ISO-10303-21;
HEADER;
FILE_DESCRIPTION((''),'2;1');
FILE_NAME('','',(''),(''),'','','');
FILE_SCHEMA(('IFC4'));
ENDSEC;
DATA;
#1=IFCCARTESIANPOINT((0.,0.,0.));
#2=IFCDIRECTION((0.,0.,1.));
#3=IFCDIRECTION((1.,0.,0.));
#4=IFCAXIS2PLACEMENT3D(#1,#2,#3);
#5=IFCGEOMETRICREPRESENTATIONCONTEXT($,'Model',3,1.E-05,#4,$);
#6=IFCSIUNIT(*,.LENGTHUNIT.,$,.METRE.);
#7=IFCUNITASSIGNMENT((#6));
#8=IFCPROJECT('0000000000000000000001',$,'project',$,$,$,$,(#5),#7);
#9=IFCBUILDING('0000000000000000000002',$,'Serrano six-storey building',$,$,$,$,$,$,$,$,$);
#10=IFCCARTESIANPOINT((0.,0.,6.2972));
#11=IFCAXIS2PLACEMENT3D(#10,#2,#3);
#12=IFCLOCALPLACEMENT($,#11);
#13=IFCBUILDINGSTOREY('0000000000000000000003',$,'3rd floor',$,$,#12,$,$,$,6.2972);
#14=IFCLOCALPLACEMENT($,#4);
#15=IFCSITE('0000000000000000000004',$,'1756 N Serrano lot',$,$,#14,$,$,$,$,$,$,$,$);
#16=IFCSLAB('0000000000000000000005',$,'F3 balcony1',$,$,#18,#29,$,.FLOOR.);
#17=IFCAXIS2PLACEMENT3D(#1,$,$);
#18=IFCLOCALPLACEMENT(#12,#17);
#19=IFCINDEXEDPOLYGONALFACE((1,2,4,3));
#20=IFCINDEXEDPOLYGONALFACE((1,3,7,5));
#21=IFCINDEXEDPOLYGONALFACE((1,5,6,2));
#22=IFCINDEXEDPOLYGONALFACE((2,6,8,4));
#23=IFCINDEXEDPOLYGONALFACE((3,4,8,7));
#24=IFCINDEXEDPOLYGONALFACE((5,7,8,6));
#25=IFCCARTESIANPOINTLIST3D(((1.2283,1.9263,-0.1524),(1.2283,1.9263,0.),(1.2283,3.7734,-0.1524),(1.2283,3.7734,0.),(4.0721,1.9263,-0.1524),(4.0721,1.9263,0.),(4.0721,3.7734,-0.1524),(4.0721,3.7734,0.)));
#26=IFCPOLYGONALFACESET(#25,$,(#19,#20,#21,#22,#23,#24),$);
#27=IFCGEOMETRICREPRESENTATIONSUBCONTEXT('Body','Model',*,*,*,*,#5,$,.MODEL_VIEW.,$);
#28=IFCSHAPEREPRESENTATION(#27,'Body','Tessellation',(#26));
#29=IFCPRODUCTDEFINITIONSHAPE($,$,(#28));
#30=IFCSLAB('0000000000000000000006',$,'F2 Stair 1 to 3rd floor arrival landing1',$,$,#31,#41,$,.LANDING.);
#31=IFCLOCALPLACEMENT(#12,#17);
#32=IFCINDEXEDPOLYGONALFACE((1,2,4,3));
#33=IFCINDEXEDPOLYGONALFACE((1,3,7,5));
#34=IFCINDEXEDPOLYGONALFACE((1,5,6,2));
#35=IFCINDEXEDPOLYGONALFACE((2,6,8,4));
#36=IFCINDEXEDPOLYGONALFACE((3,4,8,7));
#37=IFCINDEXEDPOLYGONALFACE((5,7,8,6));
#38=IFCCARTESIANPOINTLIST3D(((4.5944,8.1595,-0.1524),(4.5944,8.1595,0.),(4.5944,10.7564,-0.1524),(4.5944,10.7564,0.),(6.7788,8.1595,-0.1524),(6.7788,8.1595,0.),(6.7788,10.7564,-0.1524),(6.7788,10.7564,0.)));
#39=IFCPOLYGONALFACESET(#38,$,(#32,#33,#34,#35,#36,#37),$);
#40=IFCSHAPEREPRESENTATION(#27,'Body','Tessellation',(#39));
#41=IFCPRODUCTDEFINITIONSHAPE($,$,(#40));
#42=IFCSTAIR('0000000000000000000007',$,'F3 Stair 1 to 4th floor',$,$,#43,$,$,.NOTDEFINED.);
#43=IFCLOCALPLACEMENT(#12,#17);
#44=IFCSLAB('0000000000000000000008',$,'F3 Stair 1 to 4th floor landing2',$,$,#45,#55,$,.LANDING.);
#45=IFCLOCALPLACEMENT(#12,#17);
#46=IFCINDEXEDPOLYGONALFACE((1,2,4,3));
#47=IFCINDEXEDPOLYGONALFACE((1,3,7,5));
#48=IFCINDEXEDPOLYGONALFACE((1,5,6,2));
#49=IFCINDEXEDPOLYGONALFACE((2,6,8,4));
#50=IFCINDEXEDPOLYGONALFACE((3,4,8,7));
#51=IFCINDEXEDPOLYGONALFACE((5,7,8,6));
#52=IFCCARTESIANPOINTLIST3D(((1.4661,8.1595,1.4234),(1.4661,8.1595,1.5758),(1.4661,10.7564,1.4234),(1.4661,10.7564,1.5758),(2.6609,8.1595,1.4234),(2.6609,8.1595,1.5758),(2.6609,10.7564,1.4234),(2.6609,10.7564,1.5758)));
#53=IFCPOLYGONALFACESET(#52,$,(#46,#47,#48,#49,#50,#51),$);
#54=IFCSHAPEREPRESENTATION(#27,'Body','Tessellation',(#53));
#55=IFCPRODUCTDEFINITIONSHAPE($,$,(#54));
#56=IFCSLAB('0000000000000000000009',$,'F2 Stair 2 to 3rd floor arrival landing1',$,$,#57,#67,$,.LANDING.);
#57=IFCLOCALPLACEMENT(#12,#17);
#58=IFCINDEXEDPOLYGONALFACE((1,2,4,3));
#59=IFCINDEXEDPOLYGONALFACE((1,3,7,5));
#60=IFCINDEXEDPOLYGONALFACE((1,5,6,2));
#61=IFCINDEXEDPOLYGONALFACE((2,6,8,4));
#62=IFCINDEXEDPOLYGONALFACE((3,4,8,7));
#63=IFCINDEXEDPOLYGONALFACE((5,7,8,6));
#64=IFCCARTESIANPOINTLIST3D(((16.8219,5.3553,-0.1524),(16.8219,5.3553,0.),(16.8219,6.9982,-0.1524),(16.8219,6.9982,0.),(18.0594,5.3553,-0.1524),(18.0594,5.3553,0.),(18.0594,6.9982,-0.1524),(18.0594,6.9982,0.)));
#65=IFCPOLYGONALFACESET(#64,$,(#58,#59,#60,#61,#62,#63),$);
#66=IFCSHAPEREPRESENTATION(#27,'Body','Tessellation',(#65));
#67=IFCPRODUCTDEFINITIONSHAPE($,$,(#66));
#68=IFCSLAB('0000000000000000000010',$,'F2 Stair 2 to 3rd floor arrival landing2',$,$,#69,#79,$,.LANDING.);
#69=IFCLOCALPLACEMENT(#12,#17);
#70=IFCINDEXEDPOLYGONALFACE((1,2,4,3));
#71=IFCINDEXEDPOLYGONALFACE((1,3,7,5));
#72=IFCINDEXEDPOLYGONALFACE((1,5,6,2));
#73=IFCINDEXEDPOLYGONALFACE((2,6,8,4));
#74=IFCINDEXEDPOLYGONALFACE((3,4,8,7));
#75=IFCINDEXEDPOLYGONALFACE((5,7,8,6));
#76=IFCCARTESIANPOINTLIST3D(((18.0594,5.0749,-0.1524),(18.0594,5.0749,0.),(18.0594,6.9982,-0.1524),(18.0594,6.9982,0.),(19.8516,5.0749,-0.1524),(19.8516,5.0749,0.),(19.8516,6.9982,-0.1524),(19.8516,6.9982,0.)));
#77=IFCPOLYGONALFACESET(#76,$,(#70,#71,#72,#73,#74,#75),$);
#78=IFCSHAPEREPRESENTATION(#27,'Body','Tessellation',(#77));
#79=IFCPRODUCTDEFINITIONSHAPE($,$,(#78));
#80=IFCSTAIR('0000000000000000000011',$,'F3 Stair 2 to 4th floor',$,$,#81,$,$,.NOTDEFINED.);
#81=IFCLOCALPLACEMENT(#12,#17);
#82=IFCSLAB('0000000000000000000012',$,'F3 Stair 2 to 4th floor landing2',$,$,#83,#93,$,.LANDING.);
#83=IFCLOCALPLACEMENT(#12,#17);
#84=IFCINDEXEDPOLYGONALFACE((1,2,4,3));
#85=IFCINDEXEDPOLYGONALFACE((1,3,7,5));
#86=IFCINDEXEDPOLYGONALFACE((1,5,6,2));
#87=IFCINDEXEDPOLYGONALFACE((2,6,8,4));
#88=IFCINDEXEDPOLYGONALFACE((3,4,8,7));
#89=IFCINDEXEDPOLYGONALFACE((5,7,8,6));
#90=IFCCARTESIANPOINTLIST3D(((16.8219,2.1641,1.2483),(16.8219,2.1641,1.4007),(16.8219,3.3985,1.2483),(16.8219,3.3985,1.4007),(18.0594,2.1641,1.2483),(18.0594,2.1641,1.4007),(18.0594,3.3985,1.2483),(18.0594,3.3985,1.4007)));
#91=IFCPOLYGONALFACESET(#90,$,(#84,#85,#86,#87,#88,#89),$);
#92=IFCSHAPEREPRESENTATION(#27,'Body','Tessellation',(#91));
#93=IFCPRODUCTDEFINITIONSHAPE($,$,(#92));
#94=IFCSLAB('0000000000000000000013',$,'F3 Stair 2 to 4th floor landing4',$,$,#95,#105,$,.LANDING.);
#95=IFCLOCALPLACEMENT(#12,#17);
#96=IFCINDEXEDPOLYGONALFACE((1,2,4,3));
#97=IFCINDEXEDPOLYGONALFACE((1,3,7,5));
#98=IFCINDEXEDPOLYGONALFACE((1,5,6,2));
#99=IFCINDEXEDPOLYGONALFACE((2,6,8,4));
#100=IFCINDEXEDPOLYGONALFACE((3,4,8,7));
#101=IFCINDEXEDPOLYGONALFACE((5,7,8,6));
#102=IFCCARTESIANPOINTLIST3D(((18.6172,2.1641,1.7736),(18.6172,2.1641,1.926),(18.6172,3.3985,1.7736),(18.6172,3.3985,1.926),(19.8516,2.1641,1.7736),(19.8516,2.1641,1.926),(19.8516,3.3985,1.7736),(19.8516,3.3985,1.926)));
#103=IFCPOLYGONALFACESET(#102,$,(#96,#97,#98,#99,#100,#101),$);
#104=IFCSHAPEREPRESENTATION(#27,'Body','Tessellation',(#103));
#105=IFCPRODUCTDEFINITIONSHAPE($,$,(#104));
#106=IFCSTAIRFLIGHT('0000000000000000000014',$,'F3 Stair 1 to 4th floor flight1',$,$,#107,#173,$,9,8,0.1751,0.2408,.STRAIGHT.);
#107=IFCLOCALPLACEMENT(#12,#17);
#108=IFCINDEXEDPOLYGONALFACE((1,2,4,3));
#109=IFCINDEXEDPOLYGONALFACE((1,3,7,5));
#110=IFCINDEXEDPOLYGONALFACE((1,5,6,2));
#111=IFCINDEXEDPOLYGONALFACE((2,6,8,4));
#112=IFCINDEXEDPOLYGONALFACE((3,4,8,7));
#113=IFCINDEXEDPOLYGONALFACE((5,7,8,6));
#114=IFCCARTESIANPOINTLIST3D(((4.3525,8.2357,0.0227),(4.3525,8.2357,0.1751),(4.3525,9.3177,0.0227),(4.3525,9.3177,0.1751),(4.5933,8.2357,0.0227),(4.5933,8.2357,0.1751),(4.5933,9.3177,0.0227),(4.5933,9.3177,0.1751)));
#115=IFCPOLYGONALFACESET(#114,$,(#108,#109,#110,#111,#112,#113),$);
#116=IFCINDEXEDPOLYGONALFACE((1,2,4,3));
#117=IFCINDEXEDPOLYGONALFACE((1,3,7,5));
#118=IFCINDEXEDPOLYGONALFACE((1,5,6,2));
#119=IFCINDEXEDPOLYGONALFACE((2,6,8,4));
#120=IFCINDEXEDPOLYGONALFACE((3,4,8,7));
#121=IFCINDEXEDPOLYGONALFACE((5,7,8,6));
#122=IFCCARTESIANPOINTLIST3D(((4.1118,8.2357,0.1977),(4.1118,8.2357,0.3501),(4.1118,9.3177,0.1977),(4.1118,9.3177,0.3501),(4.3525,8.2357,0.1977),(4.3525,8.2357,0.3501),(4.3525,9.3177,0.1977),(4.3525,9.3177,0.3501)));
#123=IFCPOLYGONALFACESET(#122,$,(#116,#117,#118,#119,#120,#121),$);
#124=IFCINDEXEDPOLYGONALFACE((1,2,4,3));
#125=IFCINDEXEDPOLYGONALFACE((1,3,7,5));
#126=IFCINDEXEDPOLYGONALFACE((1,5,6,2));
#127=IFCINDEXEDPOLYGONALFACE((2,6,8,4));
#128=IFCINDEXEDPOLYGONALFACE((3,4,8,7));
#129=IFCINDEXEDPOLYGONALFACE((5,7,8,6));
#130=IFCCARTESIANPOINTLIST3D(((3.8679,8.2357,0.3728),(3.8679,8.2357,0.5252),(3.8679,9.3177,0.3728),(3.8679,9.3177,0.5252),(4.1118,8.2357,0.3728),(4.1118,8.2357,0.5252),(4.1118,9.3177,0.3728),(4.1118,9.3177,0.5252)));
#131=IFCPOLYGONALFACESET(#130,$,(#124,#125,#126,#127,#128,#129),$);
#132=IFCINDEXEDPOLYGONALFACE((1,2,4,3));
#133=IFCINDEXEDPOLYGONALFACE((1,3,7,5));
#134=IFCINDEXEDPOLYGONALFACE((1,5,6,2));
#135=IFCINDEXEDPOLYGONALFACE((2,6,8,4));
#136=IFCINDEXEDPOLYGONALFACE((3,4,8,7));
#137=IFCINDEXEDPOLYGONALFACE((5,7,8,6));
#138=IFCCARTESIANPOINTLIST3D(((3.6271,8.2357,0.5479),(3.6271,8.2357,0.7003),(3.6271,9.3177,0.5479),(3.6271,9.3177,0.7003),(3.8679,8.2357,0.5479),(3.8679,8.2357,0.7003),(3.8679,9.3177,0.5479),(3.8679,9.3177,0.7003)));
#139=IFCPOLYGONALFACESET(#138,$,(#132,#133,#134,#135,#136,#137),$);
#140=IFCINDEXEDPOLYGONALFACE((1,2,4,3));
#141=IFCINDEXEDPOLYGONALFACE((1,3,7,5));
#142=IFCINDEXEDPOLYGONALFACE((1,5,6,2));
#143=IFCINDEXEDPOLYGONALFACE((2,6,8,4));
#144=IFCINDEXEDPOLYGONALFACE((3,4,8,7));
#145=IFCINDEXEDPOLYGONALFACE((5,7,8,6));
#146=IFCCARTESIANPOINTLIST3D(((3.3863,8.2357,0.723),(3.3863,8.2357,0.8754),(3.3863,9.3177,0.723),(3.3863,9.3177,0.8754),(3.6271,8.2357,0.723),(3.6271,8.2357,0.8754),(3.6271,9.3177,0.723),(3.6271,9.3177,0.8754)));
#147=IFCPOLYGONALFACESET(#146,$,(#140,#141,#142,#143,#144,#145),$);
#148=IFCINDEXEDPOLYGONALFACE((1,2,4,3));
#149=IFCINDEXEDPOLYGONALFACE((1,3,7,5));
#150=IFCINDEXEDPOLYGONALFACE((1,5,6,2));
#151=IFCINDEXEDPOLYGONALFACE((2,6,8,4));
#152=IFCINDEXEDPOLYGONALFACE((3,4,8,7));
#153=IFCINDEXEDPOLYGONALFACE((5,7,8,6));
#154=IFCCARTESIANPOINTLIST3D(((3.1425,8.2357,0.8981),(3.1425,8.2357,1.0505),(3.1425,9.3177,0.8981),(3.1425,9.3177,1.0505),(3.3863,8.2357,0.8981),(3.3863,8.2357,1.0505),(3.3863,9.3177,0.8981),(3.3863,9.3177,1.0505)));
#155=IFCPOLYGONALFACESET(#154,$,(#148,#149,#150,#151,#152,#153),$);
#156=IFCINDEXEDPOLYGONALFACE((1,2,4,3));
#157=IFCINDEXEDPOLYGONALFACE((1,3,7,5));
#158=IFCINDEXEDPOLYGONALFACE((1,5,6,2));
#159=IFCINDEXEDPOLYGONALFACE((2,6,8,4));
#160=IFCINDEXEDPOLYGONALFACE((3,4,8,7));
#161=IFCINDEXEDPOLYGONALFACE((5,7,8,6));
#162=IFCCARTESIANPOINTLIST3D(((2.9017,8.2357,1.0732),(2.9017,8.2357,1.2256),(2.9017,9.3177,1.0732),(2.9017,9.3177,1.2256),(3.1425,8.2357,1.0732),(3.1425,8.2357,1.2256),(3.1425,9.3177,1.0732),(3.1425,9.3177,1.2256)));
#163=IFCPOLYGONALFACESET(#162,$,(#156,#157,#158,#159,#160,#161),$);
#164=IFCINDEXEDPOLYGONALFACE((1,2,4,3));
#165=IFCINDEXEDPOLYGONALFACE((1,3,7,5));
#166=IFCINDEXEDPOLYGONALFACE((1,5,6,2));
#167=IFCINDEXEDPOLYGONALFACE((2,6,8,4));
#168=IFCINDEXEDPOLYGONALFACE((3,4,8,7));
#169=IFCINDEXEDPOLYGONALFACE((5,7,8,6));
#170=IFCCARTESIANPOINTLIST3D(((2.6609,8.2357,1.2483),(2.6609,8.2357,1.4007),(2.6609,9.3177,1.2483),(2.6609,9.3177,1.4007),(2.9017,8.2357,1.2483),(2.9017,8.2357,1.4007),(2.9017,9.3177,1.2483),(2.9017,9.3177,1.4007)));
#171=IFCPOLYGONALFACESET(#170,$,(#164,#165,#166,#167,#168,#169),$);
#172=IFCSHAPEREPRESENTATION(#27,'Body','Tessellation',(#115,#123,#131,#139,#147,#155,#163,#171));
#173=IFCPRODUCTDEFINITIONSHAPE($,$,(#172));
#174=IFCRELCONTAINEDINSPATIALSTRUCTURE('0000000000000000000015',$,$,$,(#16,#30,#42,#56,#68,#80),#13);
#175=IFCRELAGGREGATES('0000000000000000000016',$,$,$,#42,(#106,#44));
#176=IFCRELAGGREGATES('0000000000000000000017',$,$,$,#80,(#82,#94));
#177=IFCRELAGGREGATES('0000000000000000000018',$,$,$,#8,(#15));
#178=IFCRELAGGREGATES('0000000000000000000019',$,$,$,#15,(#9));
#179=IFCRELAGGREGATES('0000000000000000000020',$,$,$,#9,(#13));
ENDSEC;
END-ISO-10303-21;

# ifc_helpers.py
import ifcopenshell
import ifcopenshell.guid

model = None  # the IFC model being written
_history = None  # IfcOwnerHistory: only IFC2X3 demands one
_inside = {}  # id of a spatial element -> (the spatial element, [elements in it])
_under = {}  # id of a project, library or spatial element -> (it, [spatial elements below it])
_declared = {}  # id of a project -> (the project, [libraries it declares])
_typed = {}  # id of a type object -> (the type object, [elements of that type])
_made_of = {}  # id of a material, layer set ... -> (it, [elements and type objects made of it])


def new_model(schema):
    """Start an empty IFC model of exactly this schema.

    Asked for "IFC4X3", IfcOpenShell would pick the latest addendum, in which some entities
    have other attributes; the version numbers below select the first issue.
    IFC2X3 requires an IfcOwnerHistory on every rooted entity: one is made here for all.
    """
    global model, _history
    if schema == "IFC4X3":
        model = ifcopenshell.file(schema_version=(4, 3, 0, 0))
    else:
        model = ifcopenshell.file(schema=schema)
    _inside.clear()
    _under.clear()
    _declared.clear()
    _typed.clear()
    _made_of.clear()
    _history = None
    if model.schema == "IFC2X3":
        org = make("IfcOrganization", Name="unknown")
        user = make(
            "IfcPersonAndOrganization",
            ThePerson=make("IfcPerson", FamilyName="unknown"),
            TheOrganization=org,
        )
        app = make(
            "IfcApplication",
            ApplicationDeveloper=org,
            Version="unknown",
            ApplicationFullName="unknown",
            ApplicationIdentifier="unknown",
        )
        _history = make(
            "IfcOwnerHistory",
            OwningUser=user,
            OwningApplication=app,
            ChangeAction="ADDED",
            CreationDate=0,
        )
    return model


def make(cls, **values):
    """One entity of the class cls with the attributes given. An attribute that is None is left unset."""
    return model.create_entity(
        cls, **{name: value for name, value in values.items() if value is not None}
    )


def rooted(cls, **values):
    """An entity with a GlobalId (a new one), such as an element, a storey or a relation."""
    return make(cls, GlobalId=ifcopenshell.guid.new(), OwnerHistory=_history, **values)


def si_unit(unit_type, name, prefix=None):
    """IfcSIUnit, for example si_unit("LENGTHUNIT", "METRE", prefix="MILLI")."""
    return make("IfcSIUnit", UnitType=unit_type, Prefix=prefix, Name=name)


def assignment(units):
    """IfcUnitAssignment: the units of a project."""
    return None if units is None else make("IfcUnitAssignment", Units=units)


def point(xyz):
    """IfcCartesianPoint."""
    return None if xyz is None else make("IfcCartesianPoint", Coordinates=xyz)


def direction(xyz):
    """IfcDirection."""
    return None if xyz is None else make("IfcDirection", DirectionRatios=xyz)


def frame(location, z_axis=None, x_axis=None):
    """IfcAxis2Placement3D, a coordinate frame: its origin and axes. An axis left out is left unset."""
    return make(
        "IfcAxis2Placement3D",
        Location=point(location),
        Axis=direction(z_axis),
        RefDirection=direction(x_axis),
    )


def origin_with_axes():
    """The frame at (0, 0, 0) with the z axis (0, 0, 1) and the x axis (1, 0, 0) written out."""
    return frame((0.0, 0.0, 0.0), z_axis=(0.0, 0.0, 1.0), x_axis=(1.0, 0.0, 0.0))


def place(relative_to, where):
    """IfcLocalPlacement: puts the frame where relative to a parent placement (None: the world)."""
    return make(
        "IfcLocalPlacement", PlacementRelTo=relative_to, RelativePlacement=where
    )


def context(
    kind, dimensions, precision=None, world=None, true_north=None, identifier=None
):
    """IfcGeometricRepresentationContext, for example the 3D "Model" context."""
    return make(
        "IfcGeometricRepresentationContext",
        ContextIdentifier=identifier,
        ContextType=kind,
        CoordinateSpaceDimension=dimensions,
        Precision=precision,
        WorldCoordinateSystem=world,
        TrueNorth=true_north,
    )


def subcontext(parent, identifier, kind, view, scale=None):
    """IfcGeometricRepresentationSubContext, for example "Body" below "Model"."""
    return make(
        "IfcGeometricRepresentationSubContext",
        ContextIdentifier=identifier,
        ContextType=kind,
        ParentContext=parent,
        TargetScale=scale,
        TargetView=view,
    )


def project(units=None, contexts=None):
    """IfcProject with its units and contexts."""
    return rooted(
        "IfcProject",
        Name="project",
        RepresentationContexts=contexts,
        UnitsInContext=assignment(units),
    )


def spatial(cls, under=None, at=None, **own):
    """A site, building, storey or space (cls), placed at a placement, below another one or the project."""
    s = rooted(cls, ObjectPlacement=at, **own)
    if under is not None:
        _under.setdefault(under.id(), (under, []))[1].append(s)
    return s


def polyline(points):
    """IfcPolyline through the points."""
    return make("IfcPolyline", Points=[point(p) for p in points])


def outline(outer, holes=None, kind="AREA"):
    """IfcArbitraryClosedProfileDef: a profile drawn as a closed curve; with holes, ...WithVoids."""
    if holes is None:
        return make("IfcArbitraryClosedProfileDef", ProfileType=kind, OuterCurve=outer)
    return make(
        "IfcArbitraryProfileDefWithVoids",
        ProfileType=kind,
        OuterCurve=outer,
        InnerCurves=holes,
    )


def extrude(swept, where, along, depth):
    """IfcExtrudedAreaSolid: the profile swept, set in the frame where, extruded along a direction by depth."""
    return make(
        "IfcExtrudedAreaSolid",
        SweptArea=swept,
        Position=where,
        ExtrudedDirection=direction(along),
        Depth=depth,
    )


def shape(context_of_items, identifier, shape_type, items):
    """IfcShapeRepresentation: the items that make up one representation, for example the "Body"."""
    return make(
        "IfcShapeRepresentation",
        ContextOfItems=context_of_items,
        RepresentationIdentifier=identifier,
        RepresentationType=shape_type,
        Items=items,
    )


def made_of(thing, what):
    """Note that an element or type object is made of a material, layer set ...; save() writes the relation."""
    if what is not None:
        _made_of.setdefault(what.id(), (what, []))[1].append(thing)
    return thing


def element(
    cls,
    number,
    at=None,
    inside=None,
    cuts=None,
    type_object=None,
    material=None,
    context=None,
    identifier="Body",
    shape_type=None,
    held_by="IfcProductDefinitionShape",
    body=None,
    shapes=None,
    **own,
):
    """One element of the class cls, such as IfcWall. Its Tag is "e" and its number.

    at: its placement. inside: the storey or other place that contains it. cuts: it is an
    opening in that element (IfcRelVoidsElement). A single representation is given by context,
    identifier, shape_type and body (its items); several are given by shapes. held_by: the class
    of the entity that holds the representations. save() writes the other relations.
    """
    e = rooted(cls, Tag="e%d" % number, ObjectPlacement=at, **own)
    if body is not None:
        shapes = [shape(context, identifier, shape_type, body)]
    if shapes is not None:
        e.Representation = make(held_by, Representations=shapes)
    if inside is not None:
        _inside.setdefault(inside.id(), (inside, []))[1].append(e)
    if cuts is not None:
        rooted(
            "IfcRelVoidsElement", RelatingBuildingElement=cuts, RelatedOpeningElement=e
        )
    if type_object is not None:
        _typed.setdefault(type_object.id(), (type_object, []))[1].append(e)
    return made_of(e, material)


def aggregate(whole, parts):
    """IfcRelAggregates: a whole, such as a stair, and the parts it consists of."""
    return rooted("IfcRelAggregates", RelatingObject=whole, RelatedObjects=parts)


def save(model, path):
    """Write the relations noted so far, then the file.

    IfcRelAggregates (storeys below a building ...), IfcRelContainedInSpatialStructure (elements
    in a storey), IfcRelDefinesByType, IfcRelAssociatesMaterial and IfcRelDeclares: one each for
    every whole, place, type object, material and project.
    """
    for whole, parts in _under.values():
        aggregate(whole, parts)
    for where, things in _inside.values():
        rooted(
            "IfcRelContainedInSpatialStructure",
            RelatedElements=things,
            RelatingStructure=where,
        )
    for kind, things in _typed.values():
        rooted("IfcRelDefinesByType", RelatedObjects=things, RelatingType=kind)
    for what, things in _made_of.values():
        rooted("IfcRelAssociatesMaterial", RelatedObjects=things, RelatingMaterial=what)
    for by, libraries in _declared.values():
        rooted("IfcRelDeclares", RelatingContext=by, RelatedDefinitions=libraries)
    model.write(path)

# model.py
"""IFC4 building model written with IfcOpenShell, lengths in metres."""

from ifc_helpers import new_model, si_unit, frame, origin_with_axes, place, context, subcontext, project, spatial, polyline, outline, extrude, element, aggregate, save


model = new_model("IFC4")

# Units and contexts
model_context = context("Model", 3, precision=1e-05, world=origin_with_axes())
body_context = subcontext(model_context, "Body", "Model", "MODEL_VIEW")
ifc_project = project(units=[si_unit("LENGTHUNIT", "METRE")], contexts=[model_context])

# Site, building, storey
site_placement = place(None, origin_with_axes())
site = spatial("IfcSite", under=ifc_project, at=site_placement, Name="1756 N Serrano lot")
building = spatial("IfcBuilding", under=site, Name="Serrano six-storey building")
storey_placement = place(None, frame((0.0, 0.0, 6.2972), z_axis=(0.0, 0.0, 1.0), x_axis=(1.0, 0.0, 0.0)))
storey = spatial("IfcBuildingStorey", under=building, at=storey_placement, Name="3rd floor", Elevation=6.2972)

# Slabs
slab_1_placement = place(storey_placement, frame((0.0, 0.0, -6.2972), z_axis=(0.0, 0.0, 1.0), x_axis=(1.0, 0.0, 0.0)))
element("IfcSlab", 1, at=slab_1_placement, inside=storey, Name="F3 balcony1", PredefinedType="FLOOR", context=body_context, shape_type="SweptSolid", body=[
    extrude(outline(polyline([(4.0721, 1.9263), (4.0721, 3.7734), (1.2283, 3.7734), (1.2283, 1.9263), (4.0721, 1.9263)])), frame((0.0, 0.0, 6.1448)), (0.0, 0.0, 1.0), 0.1524),
])
slab_2_placement = place(storey_placement, frame((0.0, 0.0, -6.2972), z_axis=(0.0, 0.0, 1.0), x_axis=(1.0, 0.0, 0.0)))
element("IfcSlab", 2, at=slab_2_placement, inside=storey, Name="F2 Stair 1 to 3rd floor arrival landing1", PredefinedType="LANDING", context=body_context, shape_type="SweptSolid", body=[
    extrude(outline(polyline([(6.7788, 8.1595), (6.7788, 10.7564), (4.5944, 10.7564), (4.5944, 8.1595), (6.7788, 8.1595)])), frame((0.0, 0.0, 6.1448)), (0.0, 0.0, 1.0), 0.1524),
])

# Stair, slab
stair_1 = element("IfcStair", 3, inside=storey, Name="F3 Stair 1 to 4th floor", PredefinedType="NOTDEFINED")
slab_3_placement = place(None, origin_with_axes())
slab_3 = element("IfcSlab", 4, at=slab_3_placement, Name="F3 Stair 1 to 4th floor landing2", PredefinedType="LANDING", context=body_context, shape_type="SweptSolid", body=[
    extrude(outline(polyline([(2.6609, 8.1595), (2.6609, 10.7564), (1.4661, 10.7564), (1.4661, 8.1595), (2.6609, 8.1595)])), frame((0.0, 0.0, 7.7206)), (0.0, 0.0, 1.0), 0.1524),
])

# Slabs
slab_4_placement = place(storey_placement, frame((0.0, 0.0, -6.2972), z_axis=(0.0, 0.0, 1.0), x_axis=(1.0, 0.0, 0.0)))
element("IfcSlab", 5, at=slab_4_placement, inside=storey, Name="F2 Stair 2 to 3rd floor arrival landing1", PredefinedType="LANDING", context=body_context, shape_type="SweptSolid", body=[
    extrude(outline(polyline([(18.0594, 5.3553), (18.0594, 6.9982), (16.8219, 6.9982), (16.8219, 5.3553), (18.0594, 5.3553)])), frame((0.0, 0.0, 6.1448)), (0.0, 0.0, 1.0), 0.1524),
])
slab_5_placement = place(storey_placement, frame((0.0, 0.0, -6.2972), z_axis=(0.0, 0.0, 1.0), x_axis=(1.0, 0.0, 0.0)))
element("IfcSlab", 6, at=slab_5_placement, inside=storey, Name="F2 Stair 2 to 3rd floor arrival landing2", PredefinedType="LANDING", context=body_context, shape_type="SweptSolid", body=[
    extrude(outline(polyline([(19.8516, 5.0749), (19.8516, 6.9982), (18.0594, 6.9982), (18.0594, 5.0749), (19.8516, 5.0749)])), frame((0.0, 0.0, 6.1448)), (0.0, 0.0, 1.0), 0.1524),
])

# Stair, slabs
stair_2 = element("IfcStair", 7, inside=storey, Name="F3 Stair 2 to 4th floor", PredefinedType="NOTDEFINED")
slab_6_placement = place(None, origin_with_axes())
slab_6 = element("IfcSlab", 8, at=slab_6_placement, Name="F3 Stair 2 to 4th floor landing2", PredefinedType="LANDING", context=body_context, shape_type="SweptSolid", body=[
    extrude(outline(polyline([(18.0594, 2.1641), (18.0594, 3.3985), (16.8219, 3.3985), (16.8219, 2.1641), (18.0594, 2.1641)])), frame((0.0, 0.0, 7.5455)), (0.0, 0.0, 1.0), 0.1524),
])
slab_7_placement = place(None, origin_with_axes())
slab_7 = element("IfcSlab", 9, at=slab_7_placement, Name="F3 Stair 2 to 4th floor landing4", PredefinedType="LANDING", context=body_context, shape_type="SweptSolid", body=[
    extrude(outline(polyline([(19.8516, 2.1641), (19.8516, 3.3985), (18.6172, 3.3985), (18.6172, 2.1641), (19.8516, 2.1641)])), frame((0.0, 0.0, 8.0708)), (0.0, 0.0, 1.0), 0.1524),
])

# Stair flight
stair_flight_1_placement = place(None, origin_with_axes())
stair_flight_1 = element("IfcStairFlight", 10, at=stair_flight_1_placement, Name="F3 Stair 1 to 4th floor flight1", NumberOfRisers=9, NumberOfTreads=8, PredefinedType="STRAIGHT", RiserHeight=0.1751, TreadLength=0.2408, context=body_context, shape_type="SweptSolid", body=[
    extrude(outline(polyline([(4.5933, 8.2357), (4.5933, 9.3177), (4.3525, 9.3177), (4.3525, 8.2357), (4.5933, 8.2357)])), frame((0.0, 0.0, 6.3199)), (0.0, 0.0, 1.0), 0.1524),
    extrude(outline(polyline([(4.3525, 8.2357), (4.3525, 9.3177), (4.1118, 9.3177), (4.1118, 8.2357), (4.3525, 8.2357)])), frame((0.0, 0.0, 6.4949)), (0.0, 0.0, 1.0), 0.1524),
    extrude(outline(polyline([(4.1118, 8.2357), (4.1118, 9.3177), (3.8679, 9.3177), (3.8679, 8.2357), (4.1118, 8.2357)])), frame((0.0, 0.0, 6.67)), (0.0, 0.0, 1.0), 0.1524),
    extrude(outline(polyline([(3.8679, 8.2357), (3.8679, 9.3177), (3.6271, 9.3177), (3.6271, 8.2357), (3.8679, 8.2357)])), frame((0.0, 0.0, 6.8451)), (0.0, 0.0, 1.0), 0.1524),
    extrude(outline(polyline([(3.6271, 8.2357), (3.6271, 9.3177), (3.3863, 9.3177), (3.3863, 8.2357), (3.6271, 8.2357)])), frame((0.0, 0.0, 7.0202)), (0.0, 0.0, 1.0), 0.1524),
    extrude(outline(polyline([(3.3863, 8.2357), (3.3863, 9.3177), (3.1425, 9.3177), (3.1425, 8.2357), (3.3863, 8.2357)])), frame((0.0, 0.0, 7.1953)), (0.0, 0.0, 1.0), 0.1524),
    extrude(outline(polyline([(3.1425, 8.2357), (3.1425, 9.3177), (2.9017, 9.3177), (2.9017, 8.2357), (3.1425, 8.2357)])), frame((0.0, 0.0, 7.3704)), (0.0, 0.0, 1.0), 0.1524),
    extrude(outline(polyline([(2.9017, 8.2357), (2.9017, 9.3177), (2.6609, 9.3177), (2.6609, 8.2357), (2.9017, 8.2357)])), frame((0.0, 0.0, 7.5455)), (0.0, 0.0, 1.0), 0.1524),
])
aggregate(stair_1, [stair_flight_1, slab_3])
aggregate(stair_2, [slab_6, slab_7])

save(model, "model.ifc")
